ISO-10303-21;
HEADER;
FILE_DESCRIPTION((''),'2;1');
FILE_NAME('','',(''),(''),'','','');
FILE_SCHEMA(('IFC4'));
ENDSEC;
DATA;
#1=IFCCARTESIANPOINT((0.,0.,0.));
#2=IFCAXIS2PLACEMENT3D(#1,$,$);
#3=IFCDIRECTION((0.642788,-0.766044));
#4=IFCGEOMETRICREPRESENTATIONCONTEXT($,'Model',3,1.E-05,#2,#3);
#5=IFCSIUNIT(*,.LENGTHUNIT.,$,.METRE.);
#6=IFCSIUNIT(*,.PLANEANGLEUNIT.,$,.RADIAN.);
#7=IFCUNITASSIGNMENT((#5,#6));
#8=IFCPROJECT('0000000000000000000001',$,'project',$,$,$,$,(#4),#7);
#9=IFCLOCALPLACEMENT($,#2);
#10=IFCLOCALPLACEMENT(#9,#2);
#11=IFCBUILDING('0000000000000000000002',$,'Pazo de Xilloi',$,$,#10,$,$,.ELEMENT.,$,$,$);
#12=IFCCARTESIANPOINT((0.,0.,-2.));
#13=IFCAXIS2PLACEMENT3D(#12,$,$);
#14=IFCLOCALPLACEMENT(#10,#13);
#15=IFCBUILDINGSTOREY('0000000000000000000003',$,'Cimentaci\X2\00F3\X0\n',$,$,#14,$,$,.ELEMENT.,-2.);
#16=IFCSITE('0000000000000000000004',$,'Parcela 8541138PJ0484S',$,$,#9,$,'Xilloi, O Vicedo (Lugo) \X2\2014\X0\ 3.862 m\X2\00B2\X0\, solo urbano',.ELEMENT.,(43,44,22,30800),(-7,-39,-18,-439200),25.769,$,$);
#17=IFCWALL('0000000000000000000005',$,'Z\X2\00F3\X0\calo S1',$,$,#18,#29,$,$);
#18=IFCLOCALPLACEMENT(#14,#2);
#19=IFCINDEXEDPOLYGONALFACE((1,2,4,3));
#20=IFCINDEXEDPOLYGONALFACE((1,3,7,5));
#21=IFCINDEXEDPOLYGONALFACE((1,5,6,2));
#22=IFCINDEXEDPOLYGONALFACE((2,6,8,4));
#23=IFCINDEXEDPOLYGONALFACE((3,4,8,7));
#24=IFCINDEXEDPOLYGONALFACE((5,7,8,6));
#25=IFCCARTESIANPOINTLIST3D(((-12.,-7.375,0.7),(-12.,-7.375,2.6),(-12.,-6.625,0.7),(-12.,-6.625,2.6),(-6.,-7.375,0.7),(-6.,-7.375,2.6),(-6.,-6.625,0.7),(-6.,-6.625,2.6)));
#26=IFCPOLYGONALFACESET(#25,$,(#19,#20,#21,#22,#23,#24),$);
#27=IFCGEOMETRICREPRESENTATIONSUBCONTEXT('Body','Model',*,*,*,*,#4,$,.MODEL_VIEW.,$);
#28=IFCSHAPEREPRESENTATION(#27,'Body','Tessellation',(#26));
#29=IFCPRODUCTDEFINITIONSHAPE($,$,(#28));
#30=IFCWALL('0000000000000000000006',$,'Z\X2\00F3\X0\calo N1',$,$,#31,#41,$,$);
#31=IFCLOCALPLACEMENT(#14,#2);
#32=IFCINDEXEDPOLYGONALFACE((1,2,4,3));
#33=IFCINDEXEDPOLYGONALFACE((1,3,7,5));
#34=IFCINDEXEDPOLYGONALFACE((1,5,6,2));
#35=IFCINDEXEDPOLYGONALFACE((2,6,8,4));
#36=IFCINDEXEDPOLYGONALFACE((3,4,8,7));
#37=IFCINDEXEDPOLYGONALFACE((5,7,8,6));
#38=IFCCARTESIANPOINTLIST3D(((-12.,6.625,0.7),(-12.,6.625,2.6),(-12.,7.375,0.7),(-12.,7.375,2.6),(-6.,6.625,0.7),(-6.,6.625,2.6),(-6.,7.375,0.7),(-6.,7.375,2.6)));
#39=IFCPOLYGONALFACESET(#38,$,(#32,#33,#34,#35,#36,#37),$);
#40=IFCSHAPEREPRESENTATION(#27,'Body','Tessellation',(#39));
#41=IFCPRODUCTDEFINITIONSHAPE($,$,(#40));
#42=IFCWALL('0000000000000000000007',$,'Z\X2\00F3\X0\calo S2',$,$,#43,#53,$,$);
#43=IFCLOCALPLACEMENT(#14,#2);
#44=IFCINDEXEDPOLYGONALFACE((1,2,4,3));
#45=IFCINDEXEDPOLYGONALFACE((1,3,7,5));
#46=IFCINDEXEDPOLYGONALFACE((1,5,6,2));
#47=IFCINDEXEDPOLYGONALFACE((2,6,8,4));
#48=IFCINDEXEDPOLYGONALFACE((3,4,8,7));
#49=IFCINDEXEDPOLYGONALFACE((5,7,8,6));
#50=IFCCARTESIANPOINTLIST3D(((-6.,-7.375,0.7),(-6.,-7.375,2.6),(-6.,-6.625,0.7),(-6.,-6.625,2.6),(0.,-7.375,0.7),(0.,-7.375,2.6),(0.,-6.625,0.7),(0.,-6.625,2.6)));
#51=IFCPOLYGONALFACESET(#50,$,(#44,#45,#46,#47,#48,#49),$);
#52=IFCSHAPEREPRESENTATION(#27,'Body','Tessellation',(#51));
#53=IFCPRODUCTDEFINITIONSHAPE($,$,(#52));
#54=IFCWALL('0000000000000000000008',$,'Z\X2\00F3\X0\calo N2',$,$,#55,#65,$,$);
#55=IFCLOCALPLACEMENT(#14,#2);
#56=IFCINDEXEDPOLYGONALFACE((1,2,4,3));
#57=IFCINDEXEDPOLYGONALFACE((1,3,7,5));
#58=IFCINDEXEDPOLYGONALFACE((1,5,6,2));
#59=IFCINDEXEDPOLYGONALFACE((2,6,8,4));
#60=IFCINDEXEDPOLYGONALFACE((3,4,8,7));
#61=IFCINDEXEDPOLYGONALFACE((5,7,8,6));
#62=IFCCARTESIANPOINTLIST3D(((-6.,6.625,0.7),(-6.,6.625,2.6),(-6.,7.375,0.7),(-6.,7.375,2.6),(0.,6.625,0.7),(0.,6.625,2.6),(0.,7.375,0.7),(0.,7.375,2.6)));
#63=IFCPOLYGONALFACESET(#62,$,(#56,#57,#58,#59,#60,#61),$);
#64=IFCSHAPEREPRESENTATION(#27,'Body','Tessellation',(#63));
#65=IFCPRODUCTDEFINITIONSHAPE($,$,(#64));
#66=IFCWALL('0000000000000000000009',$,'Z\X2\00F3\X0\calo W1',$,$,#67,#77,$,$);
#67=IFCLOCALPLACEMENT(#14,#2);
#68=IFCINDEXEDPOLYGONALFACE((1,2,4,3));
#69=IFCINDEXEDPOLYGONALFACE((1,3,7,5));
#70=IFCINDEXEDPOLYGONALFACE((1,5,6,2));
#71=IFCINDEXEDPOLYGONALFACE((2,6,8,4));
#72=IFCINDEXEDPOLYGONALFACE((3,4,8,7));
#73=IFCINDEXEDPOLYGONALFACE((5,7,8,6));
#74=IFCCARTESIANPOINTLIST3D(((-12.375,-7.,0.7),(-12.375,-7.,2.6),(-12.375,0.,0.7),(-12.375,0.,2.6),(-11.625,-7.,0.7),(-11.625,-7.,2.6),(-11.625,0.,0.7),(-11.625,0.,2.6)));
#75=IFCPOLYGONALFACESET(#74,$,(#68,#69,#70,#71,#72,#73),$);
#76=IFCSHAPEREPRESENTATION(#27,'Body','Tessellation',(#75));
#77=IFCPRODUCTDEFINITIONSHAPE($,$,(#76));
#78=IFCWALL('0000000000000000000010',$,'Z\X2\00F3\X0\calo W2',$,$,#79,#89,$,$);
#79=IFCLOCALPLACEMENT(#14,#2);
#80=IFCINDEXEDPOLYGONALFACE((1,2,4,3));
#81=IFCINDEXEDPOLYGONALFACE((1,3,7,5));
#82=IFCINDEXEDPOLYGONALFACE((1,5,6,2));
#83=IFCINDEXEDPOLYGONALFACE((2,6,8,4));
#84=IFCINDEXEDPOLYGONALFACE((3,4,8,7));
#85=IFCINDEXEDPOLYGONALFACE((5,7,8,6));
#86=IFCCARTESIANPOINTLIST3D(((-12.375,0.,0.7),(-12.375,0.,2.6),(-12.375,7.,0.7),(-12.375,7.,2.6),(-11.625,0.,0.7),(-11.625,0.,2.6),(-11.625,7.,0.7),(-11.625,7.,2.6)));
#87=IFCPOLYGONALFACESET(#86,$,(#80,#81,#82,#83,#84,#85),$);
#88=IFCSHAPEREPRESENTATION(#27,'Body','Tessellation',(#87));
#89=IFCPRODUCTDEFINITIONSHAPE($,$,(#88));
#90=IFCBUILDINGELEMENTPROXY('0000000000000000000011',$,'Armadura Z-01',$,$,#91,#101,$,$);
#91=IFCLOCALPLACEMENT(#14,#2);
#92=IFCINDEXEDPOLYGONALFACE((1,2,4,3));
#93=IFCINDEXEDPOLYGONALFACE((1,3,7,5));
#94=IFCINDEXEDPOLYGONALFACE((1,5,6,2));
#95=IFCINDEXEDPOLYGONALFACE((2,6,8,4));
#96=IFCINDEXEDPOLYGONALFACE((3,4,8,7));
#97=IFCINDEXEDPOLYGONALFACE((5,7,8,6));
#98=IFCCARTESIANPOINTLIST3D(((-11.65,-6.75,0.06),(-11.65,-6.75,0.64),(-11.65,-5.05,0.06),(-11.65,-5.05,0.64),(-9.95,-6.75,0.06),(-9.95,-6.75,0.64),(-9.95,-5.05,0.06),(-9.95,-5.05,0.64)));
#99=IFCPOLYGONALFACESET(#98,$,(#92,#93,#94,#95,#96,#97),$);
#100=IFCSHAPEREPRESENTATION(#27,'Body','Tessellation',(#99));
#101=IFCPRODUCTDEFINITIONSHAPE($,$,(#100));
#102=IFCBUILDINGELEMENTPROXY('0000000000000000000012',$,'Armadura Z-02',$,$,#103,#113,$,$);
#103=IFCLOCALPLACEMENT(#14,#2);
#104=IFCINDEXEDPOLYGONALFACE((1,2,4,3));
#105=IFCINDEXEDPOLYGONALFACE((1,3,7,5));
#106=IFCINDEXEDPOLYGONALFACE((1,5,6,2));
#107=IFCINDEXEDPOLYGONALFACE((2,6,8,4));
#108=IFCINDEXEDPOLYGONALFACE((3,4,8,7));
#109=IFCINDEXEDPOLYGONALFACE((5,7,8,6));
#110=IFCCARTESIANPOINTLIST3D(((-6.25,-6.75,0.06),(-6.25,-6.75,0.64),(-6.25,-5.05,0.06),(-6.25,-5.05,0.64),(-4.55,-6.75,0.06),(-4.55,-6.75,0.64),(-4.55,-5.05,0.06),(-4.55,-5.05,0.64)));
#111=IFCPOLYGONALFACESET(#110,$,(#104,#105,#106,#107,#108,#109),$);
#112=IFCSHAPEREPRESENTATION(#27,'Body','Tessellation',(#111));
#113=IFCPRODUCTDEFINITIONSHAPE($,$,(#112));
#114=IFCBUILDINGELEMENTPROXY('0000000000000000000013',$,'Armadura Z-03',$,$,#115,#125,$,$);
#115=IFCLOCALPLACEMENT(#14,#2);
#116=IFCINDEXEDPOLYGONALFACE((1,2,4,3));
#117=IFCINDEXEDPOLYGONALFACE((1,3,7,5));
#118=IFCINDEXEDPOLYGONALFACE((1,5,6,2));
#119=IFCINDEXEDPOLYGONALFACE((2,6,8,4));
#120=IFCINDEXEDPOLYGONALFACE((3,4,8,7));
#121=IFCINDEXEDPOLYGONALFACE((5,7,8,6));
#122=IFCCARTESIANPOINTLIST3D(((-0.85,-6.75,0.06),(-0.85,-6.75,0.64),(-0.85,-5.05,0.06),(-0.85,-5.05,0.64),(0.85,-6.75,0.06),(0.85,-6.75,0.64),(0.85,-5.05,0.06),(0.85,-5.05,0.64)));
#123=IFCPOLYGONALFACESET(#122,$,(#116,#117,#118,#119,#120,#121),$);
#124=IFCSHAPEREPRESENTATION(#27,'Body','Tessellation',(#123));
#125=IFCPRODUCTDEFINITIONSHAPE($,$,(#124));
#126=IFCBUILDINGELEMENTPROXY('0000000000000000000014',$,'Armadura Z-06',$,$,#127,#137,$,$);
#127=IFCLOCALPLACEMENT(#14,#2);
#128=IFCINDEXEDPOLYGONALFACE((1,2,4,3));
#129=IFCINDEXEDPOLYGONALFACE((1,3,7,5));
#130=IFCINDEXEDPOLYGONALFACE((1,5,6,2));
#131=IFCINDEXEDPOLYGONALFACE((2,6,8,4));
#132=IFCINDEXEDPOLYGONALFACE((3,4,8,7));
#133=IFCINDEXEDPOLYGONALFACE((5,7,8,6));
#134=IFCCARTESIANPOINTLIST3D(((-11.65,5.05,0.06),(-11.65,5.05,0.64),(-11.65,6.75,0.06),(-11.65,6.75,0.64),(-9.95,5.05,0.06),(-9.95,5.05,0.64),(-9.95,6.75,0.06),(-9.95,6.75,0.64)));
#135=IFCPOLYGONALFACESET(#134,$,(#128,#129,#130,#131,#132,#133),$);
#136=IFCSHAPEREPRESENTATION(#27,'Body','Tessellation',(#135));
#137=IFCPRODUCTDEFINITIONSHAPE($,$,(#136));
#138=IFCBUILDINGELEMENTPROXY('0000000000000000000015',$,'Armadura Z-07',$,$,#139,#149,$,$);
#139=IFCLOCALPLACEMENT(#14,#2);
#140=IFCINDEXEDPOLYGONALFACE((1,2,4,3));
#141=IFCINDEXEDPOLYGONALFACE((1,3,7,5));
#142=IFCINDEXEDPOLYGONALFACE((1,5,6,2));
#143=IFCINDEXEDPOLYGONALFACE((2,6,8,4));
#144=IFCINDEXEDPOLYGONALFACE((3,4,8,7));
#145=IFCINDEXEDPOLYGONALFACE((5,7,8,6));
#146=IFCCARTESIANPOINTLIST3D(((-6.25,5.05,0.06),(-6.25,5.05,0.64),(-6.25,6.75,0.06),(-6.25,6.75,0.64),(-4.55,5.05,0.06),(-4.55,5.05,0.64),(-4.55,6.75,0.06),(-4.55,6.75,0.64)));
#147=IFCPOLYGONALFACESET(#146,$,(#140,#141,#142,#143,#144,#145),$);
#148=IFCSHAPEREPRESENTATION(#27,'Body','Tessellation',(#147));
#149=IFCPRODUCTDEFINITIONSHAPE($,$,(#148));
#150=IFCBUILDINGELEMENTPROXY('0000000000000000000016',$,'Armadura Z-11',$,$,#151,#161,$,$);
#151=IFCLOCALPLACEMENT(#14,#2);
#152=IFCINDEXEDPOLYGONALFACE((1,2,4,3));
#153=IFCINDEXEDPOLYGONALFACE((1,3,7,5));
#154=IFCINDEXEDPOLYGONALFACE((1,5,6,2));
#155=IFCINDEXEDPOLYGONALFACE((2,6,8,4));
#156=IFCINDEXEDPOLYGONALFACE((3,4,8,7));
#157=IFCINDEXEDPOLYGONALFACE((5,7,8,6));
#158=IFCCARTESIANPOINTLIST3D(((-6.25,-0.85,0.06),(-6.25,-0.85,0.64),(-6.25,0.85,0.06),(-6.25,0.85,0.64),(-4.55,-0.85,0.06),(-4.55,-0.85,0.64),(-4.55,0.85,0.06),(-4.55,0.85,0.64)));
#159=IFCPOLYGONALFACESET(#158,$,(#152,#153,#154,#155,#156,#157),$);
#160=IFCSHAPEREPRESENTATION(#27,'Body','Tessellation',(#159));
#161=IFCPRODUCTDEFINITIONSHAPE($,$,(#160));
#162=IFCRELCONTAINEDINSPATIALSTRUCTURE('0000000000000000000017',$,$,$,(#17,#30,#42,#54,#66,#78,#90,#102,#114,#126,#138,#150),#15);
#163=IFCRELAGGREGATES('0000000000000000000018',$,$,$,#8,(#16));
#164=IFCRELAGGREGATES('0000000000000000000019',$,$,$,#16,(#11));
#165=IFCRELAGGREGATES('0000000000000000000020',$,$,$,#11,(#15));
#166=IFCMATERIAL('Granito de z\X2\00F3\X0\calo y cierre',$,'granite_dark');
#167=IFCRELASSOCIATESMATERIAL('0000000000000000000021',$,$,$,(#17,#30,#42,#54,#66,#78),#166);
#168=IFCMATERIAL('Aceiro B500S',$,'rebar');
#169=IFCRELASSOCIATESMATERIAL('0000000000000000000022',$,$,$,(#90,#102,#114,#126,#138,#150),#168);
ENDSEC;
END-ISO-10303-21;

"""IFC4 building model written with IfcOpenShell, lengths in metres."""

from ifc_helpers import new_model, si_unit, direction, frame, origin, origin_2d, place, context, subcontext, project, spatial, rectangle, extrude, material, element, save


model = new_model("IFC4")

# Units and contexts
model_context = context("Model", 3, precision=1e-05, world=origin(), true_north=direction((0.642788, -0.766044)))
body_context = subcontext(model_context, "Body", "Model", "MODEL_VIEW")
ifc_project = project(units=[si_unit("LENGTHUNIT", "METRE"), si_unit("PLANEANGLEUNIT", "RADIAN")], contexts=[model_context])

# Site, building, storey
site_placement = place(None, origin())
site = spatial("IfcSite", under=ifc_project, at=site_placement, Name="Parcela 8541138PJ0484S", LongName="Xilloi, O Vicedo (Lugo) — 3.862 m², solo urbano", CompositionType="ELEMENT", RefLatitude=(43, 44, 22, 30800), RefLongitude=(-7, -39, -18, -439200), RefElevation=25.769)
building_placement = place(site_placement, origin())
building = spatial("IfcBuilding", under=site, at=building_placement, Name="Pazo de Xilloi", CompositionType="ELEMENT")
storey_placement = place(building_placement, frame((0.0, 0.0, -2.0)))
storey = spatial("IfcBuildingStorey", under=building, at=storey_placement, Name="Cimentación", CompositionType="ELEMENT", Elevation=-2.0)

# Walls
ifc_material_1 = material(Name="Granito de zócalo y cierre", Category="granite_dark")
for number, where, name in (
    (1, (-9.0, -7.0, 1.65), "Zócalo S1"),
    (2, (-9.0, 7.0, 1.65), "Zócalo N1"),
    (3, (-3.0, -7.0, 1.65), "Zócalo S2"),
    (4, (-3.0, 7.0, 1.65), "Zócalo N2"),
):
    element("IfcWall", number, at=place(storey_placement, frame(where)), inside=storey, material=ifc_material_1, Name=name, context=body_context, shape_type="SweptSolid", body=[
        extrude(rectangle(XDim=6.0, YDim=0.75, at=origin_2d()), frame((0.0, 0.0, -0.95)), (0.0, 0.0, 1.0), 1.9),
    ])
for number, where, name in (
    (5, (-12.0, -3.5, 1.65), "Zócalo W1"),
    (6, (-12.0, 3.5, 1.65), "Zócalo W2"),
):
    element("IfcWall", number, at=place(storey_placement, frame(where)), inside=storey, material=ifc_material_1, Name=name, context=body_context, shape_type="SweptSolid", body=[
        extrude(rectangle(XDim=0.75, YDim=7.0, at=origin_2d()), frame((0.0, 0.0, -0.95)), (0.0, 0.0, 1.0), 1.9),
    ])

# Building element proxies
ifc_material_2 = material(Name="Aceiro B500S", Category="rebar")
for number, where, name in (
    (7, (-10.8, -5.9, 0.35), "Armadura Z-01"),
    (8, (-5.4, -5.9, 0.35), "Armadura Z-02"),
    (9, (0.0, -5.9, 0.35), "Armadura Z-03"),
    (10, (-10.8, 5.9, 0.35), "Armadura Z-06"),
    (11, (-5.4, 5.9, 0.35), "Armadura Z-07"),
    (12, (-5.4, 0.0, 0.35), "Armadura Z-11"),
):
    element("IfcBuildingElementProxy", number, at=place(storey_placement, frame(where)), inside=storey, material=ifc_material_2, Name=name, context=body_context, shape_type="SweptSolid", body=[
        extrude(rectangle(XDim=1.7, YDim=1.7, at=origin_2d()), frame((0.0, 0.0, -0.29)), (0.0, 0.0, 1.0), 0.58),
    ])

save(model, "model.ifc")
